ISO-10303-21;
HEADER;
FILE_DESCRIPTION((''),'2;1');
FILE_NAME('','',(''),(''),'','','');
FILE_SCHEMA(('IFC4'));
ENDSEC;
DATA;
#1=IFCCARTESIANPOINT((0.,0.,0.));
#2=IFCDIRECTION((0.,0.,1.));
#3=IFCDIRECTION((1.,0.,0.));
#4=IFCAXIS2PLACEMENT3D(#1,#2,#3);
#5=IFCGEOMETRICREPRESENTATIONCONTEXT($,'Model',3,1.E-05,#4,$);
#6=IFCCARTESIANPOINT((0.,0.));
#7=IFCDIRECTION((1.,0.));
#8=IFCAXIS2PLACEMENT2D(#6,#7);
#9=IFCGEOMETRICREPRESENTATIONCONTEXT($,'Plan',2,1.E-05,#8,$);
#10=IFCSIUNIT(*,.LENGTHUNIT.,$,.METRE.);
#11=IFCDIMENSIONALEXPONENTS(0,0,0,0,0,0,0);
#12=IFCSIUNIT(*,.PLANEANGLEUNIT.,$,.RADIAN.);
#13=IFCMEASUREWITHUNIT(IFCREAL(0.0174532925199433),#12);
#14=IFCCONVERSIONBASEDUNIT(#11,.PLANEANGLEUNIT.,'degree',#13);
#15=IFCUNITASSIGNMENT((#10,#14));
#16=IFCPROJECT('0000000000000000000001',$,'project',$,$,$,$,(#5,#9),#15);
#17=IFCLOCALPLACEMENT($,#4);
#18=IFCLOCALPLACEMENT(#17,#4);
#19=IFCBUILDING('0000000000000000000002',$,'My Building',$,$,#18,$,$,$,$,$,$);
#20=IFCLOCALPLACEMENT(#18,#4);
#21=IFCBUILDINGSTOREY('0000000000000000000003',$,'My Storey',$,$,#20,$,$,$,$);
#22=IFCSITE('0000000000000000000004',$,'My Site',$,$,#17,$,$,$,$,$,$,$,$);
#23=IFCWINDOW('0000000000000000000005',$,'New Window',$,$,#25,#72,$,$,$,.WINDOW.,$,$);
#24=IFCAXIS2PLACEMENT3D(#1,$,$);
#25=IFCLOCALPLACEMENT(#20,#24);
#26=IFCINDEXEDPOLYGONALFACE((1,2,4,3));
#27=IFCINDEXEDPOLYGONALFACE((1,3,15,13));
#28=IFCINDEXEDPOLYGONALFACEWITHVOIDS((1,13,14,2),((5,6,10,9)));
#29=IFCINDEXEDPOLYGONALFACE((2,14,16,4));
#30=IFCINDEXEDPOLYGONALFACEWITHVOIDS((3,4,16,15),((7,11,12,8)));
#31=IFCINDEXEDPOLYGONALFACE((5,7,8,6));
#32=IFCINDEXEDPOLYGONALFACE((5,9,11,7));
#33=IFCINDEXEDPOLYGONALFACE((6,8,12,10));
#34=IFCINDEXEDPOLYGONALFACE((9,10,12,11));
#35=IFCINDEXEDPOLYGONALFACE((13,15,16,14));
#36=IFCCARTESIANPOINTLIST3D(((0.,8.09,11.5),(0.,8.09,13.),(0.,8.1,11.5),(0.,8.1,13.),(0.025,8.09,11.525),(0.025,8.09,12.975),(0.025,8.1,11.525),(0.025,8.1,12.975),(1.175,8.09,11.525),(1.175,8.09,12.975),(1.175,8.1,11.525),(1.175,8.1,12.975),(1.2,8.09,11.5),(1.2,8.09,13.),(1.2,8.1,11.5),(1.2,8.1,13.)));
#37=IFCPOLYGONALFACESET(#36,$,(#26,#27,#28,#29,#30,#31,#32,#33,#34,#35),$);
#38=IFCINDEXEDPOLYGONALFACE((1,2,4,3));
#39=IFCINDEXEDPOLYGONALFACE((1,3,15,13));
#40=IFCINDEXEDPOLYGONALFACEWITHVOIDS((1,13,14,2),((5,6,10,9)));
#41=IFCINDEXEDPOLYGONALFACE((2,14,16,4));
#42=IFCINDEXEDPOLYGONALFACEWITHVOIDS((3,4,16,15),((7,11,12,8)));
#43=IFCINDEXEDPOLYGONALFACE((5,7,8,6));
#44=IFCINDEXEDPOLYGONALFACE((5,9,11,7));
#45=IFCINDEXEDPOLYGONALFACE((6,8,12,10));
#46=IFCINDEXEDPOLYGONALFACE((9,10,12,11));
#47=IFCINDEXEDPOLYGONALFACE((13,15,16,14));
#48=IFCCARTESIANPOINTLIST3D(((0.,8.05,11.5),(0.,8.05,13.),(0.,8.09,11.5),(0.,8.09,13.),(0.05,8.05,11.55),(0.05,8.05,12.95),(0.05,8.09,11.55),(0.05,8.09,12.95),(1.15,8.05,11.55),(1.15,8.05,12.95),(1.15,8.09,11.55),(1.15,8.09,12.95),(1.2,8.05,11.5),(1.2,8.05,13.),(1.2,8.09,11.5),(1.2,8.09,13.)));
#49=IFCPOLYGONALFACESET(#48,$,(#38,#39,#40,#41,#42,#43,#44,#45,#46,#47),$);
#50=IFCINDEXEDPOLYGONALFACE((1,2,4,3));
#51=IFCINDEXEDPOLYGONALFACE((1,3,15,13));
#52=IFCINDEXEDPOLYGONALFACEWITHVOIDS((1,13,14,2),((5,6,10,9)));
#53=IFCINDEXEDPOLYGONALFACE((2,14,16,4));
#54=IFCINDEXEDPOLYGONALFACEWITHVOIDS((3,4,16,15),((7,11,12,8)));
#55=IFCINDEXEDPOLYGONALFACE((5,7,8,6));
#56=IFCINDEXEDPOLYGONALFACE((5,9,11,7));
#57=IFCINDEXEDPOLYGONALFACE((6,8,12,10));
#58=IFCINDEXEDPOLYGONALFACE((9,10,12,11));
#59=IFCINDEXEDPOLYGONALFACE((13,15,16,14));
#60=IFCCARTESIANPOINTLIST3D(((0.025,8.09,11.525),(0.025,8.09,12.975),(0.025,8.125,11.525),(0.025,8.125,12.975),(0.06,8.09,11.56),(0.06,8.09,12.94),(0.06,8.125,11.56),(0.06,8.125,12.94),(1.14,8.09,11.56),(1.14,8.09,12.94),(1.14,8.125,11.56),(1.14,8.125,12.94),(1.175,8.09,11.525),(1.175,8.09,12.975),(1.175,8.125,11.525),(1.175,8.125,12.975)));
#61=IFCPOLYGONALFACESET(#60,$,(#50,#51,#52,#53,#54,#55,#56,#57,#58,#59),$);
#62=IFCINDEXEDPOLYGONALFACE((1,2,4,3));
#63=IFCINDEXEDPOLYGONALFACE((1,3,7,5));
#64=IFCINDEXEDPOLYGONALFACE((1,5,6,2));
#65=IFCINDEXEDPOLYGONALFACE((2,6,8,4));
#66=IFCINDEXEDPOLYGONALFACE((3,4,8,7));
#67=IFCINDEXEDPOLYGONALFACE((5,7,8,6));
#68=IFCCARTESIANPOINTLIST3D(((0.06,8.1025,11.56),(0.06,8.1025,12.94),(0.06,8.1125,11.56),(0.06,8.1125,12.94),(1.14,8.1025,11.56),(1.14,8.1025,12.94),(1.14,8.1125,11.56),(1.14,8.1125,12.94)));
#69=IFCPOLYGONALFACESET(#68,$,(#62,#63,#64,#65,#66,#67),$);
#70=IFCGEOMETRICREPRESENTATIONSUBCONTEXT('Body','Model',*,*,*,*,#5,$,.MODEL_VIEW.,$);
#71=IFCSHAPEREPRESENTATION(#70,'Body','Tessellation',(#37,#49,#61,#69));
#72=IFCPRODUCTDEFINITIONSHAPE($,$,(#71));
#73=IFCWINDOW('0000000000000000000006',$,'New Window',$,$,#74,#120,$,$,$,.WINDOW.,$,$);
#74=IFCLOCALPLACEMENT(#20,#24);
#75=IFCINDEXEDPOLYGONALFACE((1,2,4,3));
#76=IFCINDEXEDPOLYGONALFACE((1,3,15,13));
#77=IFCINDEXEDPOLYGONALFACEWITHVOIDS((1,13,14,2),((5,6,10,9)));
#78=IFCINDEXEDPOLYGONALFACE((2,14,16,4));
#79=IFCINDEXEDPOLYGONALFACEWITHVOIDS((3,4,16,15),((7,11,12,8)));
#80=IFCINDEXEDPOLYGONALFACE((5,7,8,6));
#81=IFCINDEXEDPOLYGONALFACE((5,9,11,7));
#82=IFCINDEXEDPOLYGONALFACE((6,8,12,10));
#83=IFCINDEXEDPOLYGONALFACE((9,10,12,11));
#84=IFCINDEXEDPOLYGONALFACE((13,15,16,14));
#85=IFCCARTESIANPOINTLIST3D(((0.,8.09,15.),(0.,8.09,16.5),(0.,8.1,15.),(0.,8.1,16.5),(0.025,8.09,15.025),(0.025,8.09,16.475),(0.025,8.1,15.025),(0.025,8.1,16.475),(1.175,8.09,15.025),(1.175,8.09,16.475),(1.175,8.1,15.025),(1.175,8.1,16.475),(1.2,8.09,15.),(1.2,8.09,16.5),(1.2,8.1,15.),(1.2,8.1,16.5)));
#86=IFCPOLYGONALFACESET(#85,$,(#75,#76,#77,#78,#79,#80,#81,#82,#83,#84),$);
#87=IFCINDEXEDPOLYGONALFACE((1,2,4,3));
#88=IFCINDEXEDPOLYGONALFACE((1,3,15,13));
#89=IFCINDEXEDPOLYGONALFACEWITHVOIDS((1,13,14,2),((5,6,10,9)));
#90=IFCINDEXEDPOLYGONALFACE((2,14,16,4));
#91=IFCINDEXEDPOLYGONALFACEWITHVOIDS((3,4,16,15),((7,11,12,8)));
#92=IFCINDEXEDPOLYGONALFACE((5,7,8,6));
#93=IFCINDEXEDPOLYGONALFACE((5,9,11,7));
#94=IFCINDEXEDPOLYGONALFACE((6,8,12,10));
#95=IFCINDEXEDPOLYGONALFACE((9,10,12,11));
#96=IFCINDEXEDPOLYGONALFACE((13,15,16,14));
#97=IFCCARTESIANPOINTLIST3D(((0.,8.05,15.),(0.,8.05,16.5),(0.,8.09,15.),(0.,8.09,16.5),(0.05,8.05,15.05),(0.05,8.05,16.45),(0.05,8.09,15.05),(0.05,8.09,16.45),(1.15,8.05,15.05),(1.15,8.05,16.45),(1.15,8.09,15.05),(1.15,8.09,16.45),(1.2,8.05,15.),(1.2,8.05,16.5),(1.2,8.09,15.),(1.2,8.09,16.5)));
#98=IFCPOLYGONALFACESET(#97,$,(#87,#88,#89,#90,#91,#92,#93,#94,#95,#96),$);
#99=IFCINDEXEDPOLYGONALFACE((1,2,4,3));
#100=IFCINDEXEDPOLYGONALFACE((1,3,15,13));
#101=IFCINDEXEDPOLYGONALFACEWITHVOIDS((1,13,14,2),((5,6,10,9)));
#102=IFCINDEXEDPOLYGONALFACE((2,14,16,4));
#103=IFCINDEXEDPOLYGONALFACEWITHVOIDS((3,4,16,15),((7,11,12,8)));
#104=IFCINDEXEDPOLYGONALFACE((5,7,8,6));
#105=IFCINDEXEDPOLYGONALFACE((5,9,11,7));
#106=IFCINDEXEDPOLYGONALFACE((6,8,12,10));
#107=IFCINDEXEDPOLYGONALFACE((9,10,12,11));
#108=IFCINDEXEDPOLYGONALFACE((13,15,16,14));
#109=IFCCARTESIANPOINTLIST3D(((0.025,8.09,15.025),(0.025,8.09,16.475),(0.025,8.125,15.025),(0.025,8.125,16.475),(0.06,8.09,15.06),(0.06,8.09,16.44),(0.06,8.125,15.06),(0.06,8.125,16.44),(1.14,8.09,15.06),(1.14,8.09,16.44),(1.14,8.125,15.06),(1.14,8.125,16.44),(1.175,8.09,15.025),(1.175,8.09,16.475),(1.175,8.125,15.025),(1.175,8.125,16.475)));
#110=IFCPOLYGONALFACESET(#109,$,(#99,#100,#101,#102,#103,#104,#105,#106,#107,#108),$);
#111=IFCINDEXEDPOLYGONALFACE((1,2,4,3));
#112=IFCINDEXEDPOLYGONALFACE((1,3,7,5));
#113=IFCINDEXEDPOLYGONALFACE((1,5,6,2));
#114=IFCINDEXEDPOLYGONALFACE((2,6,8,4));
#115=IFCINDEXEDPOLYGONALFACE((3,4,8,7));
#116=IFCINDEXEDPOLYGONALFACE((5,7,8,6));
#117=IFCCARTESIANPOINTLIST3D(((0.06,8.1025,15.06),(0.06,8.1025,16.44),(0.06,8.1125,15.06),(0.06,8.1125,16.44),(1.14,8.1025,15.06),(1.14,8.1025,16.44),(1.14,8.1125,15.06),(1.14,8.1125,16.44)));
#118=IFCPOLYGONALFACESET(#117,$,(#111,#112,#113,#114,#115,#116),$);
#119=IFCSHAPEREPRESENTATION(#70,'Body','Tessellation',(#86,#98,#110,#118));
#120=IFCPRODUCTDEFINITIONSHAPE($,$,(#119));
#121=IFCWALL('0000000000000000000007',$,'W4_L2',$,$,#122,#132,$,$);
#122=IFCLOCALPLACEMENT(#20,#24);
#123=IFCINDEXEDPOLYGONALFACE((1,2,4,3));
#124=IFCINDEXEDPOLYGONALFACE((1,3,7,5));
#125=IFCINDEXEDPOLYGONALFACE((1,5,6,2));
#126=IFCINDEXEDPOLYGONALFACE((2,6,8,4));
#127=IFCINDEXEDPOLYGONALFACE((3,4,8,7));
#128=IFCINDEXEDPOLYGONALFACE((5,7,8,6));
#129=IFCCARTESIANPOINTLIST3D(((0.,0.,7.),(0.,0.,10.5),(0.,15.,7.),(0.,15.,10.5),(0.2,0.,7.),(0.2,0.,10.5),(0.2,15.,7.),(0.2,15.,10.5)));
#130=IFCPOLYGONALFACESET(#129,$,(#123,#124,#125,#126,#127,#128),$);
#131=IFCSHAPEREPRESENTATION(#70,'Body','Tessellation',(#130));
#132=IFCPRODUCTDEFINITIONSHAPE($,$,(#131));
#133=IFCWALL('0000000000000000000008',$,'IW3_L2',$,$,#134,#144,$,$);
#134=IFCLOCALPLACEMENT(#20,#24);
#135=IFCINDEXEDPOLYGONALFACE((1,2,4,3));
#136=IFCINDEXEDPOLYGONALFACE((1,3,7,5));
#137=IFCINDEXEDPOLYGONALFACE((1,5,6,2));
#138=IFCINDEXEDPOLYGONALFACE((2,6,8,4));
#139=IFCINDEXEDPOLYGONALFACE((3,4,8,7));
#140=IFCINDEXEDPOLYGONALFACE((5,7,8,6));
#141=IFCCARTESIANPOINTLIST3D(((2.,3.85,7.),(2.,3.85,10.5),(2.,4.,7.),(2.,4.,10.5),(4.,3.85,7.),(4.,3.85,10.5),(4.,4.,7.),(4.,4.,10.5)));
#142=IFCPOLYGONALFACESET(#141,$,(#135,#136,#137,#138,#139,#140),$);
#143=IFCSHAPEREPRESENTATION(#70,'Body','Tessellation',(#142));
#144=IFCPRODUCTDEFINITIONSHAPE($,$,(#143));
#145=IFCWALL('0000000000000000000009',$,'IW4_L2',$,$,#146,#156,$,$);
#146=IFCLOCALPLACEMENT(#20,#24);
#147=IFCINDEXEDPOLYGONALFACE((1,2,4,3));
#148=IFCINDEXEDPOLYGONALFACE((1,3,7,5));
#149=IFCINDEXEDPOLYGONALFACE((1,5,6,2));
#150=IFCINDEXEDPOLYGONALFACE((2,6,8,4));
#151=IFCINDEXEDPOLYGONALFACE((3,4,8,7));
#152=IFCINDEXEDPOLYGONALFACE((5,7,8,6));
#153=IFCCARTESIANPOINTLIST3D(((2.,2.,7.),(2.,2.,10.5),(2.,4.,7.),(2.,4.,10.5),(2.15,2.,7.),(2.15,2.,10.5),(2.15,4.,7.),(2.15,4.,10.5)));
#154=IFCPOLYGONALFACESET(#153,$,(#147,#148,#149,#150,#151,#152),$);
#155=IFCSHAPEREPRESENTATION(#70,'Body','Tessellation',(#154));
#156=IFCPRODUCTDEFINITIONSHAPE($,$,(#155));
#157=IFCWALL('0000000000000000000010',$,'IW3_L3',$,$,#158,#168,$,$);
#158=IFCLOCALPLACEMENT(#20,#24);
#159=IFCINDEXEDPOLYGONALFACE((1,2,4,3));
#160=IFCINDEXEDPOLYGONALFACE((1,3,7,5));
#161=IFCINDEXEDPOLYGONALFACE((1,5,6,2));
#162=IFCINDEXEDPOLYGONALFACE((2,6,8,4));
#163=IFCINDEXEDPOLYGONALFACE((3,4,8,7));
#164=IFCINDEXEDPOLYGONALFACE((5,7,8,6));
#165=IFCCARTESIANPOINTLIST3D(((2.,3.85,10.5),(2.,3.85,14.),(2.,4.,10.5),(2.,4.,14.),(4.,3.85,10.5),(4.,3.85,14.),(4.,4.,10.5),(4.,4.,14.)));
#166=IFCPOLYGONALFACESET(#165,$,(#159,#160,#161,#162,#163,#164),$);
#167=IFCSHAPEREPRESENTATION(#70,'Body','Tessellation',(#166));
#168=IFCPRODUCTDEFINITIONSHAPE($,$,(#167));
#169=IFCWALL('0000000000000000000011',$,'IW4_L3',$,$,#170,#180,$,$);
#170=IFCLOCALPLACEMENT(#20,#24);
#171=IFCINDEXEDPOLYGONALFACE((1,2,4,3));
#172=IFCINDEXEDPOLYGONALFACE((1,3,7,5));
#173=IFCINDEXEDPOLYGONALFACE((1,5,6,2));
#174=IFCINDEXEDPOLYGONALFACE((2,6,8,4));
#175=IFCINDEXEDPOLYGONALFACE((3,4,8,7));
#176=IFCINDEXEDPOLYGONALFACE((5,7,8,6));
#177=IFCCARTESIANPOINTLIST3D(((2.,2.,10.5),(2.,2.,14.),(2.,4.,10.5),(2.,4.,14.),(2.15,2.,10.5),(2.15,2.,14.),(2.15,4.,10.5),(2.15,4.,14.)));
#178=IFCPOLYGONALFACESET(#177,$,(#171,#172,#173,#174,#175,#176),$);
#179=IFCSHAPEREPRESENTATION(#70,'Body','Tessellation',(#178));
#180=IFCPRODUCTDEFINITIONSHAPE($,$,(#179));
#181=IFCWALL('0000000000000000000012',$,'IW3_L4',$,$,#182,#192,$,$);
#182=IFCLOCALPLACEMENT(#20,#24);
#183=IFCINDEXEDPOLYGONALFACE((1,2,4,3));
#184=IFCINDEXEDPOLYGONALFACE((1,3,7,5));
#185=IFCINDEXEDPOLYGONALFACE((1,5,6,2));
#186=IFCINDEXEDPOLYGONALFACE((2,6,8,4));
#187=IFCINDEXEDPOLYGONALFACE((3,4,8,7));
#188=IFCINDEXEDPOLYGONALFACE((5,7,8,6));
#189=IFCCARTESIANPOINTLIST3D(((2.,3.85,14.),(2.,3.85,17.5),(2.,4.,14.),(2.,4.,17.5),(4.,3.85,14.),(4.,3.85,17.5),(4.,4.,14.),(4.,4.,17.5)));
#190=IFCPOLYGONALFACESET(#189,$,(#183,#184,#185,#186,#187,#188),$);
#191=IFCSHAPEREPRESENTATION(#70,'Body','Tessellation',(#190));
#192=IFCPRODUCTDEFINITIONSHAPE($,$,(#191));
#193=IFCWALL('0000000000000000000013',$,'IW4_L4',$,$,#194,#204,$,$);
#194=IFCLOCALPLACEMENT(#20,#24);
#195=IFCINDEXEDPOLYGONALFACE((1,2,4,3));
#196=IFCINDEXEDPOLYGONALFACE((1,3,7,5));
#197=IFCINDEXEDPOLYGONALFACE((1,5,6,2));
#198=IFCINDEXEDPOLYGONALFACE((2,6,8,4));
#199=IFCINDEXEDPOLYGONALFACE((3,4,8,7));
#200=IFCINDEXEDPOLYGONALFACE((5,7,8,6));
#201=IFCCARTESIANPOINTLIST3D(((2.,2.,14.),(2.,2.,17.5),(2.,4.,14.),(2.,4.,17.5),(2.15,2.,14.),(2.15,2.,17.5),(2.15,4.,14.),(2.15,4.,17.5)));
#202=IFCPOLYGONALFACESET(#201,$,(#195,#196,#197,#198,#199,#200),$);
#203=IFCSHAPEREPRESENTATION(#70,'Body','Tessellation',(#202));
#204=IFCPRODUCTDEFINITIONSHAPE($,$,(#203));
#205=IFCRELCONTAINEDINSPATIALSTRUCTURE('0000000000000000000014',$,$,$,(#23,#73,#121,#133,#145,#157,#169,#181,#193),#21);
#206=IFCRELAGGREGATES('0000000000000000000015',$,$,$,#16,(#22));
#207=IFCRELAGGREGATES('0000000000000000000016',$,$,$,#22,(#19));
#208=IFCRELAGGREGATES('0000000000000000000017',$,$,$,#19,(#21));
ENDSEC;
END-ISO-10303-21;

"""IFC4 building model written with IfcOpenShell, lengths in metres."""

from ifc_helpers import new_model, entity, si_unit, converted_unit, frame, origin_with_axes, origin_2d_with_axis, place, context, subcontext, project, spatial, line, indexed_curve, outline, extrude, element, save


model = new_model("IFC4")

# Units and contexts
model_context = context("Model", 3, precision=1e-05, world=origin_with_axes())
plan_context = context("Plan", 2, precision=1e-05, world=origin_2d_with_axis())
body_context = subcontext(model_context, "Body", "Model", "MODEL_VIEW")
ifc_project = project(units=[si_unit("LENGTHUNIT", "METRE"), converted_unit("PLANEANGLEUNIT", "degree", entity("IfcReal", 0.0174532925199433), si_unit("PLANEANGLEUNIT", "RADIAN"), dimensions=[0, 0, 0, 0, 0, 0, 0])], contexts=[model_context, plan_context])

# Site, building, storey
site_placement = place(None, origin_with_axes())
site = spatial("IfcSite", under=ifc_project, at=site_placement, Name="My Site")
building_placement = place(site_placement, origin_with_axes())
building = spatial("IfcBuilding", under=site, at=building_placement, Name="My Building")
storey_placement = place(building_placement, origin_with_axes())
storey = spatial("IfcBuildingStorey", under=building, at=storey_placement, Name="My Storey")

# Windows
for number, where, z_axis, x_axis, name in (
    (1, (0.0, 8.0, 11.5), (0.0, 0.0, 1.0), (1.0, 0.0, 0.0), "New Window"),
    (2, (0.0, 8.0, 15.0), (0.0, 0.0, 1.0), (1.0, 0.0, 0.0), "New Window"),
):
    element("IfcWindow", number, at=place(storey_placement, frame(where, z_axis=z_axis, x_axis=x_axis)), inside=storey, Name=name, PredefinedType="WINDOW", context=body_context, shape_type="SweptSolid", body=[
        extrude(outline(indexed_curve([(0.0, 0.0), (1.2, 0.0), (1.2, 1.5), (0.0, 1.5)], segments=[line(1, 2, 3, 4, 1)]), holes=[indexed_curve([(0.025, 0.025), (1.175, 0.025), (1.175, 1.475), (0.025, 1.475)], segments=[line(1, 2, 3, 4, 1)])]), frame((0.0, 0.09, 0.0), z_axis=(0.0, -1.0, 0.0), x_axis=(1.0, 0.0, 0.0)), (0.0, 0.0, -1.0), 0.01),
        extrude(outline(indexed_curve([(0.0, 0.0), (1.2, 0.0), (1.2, 1.5), (0.0, 1.5)], segments=[line(1, 2, 3, 4, 1)]), holes=[indexed_curve([(0.05, 0.05), (1.15, 0.05), (1.15, 1.45), (0.05, 1.45)], segments=[line(1, 2, 3, 4, 1)])]), frame((0.0, 0.05, 0.0), z_axis=(0.0, -1.0, 0.0), x_axis=(1.0, 0.0, 0.0)), (0.0, 0.0, -1.0), 0.04),
        extrude(outline(indexed_curve([(0.0, 0.0), (1.15, 0.0), (1.15, 1.45), (0.0, 1.45)], segments=[line(1, 2, 3, 4, 1)]), holes=[indexed_curve([(0.035, 0.035), (1.115, 0.035), (1.115, 1.415), (0.035, 1.415)], segments=[line(1, 2, 3, 4, 1)])]), frame((0.025, 0.09, 0.025), z_axis=(0.0, -1.0, 0.0), x_axis=(1.0, 0.0, 0.0)), (0.0, 0.0, -1.0), 0.035),
        extrude(outline(indexed_curve([(0.035, 0.035), (1.115, 0.035), (1.115, 1.415), (0.035, 1.415)], segments=[line(1, 2, 3, 4, 1)])), frame((0.025, 0.1025, 0.025), z_axis=(0.0, -1.0, 0.0), x_axis=(1.0, 0.0, 0.0)), (0.0, 0.0, -1.0), 0.01),
    ])

# Walls
wall_1_placement = place(storey_placement, frame((0.0, 15.0, 7.0), z_axis=(0.0, 0.0, 1.0), x_axis=(0.0, -1.0, 0.0)))
element("IfcWall", 3, at=wall_1_placement, inside=storey, Name="W4_L2", context=body_context, shape_type="SweptSolid", body=[
    extrude(outline(indexed_curve([(0.0, 0.0), (0.0, 0.2), (15.0, 0.2), (15.0, 0.0), (0.0, 0.0)], self_intersect=False)), origin_with_axes(), (0.0, 0.0, 1.0), 3.5),
])
for number, where, z_axis, x_axis, name in (
    (4, (4.0, 4.0, 7.0), (0.0, 0.0, 1.0), (-1.0, 0.0, 0.0), "IW3_L2"),
    (5, (2.0, 4.0, 7.0), (0.0, 0.0, 1.0), (0.0, -1.0, 0.0), "IW4_L2"),
):
    element("IfcWall", number, at=place(storey_placement, frame(where, z_axis=z_axis, x_axis=x_axis)), inside=storey, Name=name, context=body_context, shape_type="SweptSolid", body=[
        extrude(outline(indexed_curve([(0.0, 0.0), (0.0, 0.15), (2.0, 0.15), (2.0, 0.0), (0.0, 0.0)], self_intersect=False)), origin_with_axes(), (0.0, 0.0, 1.0), 3.5),
    ])
for number, where, z_axis, x_axis, name in (
    (6, (4.0, 4.0, 10.5), (0.0, 0.0, 1.0), (-1.0, 0.0, 0.0), "IW3_L3"),
    (7, (2.0, 4.0, 10.5), (0.0, 0.0, 1.0), (0.0, -1.0, 0.0), "IW4_L3"),
):
    element("IfcWall", number, at=place(storey_placement, frame(where, z_axis=z_axis, x_axis=x_axis)), inside=storey, Name=name, context=body_context, shape_type="SweptSolid", body=[
        extrude(outline(indexed_curve([(0.0, 0.0), (0.0, 0.15), (2.0, 0.15), (2.0, 0.0), (0.0, 0.0)], self_intersect=False)), origin_with_axes(), (0.0, 0.0, 1.0), 3.5),
    ])
for number, where, z_axis, x_axis, name in (
    (8, (4.0, 4.0, 14.0), (0.0, 0.0, 1.0), (-1.0, 0.0, 0.0), "IW3_L4"),
    (9, (2.0, 4.0, 14.0), (0.0, 0.0, 1.0), (0.0, -1.0, 0.0), "IW4_L4"),
):
    element("IfcWall", number, at=place(storey_placement, frame(where, z_axis=z_axis, x_axis=x_axis)), inside=storey, Name=name, context=body_context, shape_type="SweptSolid", body=[
        extrude(outline(indexed_curve([(0.0, 0.0), (0.0, 0.15), (2.0, 0.15), (2.0, 0.0), (0.0, 0.0)], self_intersect=False)), origin_with_axes(), (0.0, 0.0, 1.0), 3.5),
    ])

save(model, "model.ifc")
